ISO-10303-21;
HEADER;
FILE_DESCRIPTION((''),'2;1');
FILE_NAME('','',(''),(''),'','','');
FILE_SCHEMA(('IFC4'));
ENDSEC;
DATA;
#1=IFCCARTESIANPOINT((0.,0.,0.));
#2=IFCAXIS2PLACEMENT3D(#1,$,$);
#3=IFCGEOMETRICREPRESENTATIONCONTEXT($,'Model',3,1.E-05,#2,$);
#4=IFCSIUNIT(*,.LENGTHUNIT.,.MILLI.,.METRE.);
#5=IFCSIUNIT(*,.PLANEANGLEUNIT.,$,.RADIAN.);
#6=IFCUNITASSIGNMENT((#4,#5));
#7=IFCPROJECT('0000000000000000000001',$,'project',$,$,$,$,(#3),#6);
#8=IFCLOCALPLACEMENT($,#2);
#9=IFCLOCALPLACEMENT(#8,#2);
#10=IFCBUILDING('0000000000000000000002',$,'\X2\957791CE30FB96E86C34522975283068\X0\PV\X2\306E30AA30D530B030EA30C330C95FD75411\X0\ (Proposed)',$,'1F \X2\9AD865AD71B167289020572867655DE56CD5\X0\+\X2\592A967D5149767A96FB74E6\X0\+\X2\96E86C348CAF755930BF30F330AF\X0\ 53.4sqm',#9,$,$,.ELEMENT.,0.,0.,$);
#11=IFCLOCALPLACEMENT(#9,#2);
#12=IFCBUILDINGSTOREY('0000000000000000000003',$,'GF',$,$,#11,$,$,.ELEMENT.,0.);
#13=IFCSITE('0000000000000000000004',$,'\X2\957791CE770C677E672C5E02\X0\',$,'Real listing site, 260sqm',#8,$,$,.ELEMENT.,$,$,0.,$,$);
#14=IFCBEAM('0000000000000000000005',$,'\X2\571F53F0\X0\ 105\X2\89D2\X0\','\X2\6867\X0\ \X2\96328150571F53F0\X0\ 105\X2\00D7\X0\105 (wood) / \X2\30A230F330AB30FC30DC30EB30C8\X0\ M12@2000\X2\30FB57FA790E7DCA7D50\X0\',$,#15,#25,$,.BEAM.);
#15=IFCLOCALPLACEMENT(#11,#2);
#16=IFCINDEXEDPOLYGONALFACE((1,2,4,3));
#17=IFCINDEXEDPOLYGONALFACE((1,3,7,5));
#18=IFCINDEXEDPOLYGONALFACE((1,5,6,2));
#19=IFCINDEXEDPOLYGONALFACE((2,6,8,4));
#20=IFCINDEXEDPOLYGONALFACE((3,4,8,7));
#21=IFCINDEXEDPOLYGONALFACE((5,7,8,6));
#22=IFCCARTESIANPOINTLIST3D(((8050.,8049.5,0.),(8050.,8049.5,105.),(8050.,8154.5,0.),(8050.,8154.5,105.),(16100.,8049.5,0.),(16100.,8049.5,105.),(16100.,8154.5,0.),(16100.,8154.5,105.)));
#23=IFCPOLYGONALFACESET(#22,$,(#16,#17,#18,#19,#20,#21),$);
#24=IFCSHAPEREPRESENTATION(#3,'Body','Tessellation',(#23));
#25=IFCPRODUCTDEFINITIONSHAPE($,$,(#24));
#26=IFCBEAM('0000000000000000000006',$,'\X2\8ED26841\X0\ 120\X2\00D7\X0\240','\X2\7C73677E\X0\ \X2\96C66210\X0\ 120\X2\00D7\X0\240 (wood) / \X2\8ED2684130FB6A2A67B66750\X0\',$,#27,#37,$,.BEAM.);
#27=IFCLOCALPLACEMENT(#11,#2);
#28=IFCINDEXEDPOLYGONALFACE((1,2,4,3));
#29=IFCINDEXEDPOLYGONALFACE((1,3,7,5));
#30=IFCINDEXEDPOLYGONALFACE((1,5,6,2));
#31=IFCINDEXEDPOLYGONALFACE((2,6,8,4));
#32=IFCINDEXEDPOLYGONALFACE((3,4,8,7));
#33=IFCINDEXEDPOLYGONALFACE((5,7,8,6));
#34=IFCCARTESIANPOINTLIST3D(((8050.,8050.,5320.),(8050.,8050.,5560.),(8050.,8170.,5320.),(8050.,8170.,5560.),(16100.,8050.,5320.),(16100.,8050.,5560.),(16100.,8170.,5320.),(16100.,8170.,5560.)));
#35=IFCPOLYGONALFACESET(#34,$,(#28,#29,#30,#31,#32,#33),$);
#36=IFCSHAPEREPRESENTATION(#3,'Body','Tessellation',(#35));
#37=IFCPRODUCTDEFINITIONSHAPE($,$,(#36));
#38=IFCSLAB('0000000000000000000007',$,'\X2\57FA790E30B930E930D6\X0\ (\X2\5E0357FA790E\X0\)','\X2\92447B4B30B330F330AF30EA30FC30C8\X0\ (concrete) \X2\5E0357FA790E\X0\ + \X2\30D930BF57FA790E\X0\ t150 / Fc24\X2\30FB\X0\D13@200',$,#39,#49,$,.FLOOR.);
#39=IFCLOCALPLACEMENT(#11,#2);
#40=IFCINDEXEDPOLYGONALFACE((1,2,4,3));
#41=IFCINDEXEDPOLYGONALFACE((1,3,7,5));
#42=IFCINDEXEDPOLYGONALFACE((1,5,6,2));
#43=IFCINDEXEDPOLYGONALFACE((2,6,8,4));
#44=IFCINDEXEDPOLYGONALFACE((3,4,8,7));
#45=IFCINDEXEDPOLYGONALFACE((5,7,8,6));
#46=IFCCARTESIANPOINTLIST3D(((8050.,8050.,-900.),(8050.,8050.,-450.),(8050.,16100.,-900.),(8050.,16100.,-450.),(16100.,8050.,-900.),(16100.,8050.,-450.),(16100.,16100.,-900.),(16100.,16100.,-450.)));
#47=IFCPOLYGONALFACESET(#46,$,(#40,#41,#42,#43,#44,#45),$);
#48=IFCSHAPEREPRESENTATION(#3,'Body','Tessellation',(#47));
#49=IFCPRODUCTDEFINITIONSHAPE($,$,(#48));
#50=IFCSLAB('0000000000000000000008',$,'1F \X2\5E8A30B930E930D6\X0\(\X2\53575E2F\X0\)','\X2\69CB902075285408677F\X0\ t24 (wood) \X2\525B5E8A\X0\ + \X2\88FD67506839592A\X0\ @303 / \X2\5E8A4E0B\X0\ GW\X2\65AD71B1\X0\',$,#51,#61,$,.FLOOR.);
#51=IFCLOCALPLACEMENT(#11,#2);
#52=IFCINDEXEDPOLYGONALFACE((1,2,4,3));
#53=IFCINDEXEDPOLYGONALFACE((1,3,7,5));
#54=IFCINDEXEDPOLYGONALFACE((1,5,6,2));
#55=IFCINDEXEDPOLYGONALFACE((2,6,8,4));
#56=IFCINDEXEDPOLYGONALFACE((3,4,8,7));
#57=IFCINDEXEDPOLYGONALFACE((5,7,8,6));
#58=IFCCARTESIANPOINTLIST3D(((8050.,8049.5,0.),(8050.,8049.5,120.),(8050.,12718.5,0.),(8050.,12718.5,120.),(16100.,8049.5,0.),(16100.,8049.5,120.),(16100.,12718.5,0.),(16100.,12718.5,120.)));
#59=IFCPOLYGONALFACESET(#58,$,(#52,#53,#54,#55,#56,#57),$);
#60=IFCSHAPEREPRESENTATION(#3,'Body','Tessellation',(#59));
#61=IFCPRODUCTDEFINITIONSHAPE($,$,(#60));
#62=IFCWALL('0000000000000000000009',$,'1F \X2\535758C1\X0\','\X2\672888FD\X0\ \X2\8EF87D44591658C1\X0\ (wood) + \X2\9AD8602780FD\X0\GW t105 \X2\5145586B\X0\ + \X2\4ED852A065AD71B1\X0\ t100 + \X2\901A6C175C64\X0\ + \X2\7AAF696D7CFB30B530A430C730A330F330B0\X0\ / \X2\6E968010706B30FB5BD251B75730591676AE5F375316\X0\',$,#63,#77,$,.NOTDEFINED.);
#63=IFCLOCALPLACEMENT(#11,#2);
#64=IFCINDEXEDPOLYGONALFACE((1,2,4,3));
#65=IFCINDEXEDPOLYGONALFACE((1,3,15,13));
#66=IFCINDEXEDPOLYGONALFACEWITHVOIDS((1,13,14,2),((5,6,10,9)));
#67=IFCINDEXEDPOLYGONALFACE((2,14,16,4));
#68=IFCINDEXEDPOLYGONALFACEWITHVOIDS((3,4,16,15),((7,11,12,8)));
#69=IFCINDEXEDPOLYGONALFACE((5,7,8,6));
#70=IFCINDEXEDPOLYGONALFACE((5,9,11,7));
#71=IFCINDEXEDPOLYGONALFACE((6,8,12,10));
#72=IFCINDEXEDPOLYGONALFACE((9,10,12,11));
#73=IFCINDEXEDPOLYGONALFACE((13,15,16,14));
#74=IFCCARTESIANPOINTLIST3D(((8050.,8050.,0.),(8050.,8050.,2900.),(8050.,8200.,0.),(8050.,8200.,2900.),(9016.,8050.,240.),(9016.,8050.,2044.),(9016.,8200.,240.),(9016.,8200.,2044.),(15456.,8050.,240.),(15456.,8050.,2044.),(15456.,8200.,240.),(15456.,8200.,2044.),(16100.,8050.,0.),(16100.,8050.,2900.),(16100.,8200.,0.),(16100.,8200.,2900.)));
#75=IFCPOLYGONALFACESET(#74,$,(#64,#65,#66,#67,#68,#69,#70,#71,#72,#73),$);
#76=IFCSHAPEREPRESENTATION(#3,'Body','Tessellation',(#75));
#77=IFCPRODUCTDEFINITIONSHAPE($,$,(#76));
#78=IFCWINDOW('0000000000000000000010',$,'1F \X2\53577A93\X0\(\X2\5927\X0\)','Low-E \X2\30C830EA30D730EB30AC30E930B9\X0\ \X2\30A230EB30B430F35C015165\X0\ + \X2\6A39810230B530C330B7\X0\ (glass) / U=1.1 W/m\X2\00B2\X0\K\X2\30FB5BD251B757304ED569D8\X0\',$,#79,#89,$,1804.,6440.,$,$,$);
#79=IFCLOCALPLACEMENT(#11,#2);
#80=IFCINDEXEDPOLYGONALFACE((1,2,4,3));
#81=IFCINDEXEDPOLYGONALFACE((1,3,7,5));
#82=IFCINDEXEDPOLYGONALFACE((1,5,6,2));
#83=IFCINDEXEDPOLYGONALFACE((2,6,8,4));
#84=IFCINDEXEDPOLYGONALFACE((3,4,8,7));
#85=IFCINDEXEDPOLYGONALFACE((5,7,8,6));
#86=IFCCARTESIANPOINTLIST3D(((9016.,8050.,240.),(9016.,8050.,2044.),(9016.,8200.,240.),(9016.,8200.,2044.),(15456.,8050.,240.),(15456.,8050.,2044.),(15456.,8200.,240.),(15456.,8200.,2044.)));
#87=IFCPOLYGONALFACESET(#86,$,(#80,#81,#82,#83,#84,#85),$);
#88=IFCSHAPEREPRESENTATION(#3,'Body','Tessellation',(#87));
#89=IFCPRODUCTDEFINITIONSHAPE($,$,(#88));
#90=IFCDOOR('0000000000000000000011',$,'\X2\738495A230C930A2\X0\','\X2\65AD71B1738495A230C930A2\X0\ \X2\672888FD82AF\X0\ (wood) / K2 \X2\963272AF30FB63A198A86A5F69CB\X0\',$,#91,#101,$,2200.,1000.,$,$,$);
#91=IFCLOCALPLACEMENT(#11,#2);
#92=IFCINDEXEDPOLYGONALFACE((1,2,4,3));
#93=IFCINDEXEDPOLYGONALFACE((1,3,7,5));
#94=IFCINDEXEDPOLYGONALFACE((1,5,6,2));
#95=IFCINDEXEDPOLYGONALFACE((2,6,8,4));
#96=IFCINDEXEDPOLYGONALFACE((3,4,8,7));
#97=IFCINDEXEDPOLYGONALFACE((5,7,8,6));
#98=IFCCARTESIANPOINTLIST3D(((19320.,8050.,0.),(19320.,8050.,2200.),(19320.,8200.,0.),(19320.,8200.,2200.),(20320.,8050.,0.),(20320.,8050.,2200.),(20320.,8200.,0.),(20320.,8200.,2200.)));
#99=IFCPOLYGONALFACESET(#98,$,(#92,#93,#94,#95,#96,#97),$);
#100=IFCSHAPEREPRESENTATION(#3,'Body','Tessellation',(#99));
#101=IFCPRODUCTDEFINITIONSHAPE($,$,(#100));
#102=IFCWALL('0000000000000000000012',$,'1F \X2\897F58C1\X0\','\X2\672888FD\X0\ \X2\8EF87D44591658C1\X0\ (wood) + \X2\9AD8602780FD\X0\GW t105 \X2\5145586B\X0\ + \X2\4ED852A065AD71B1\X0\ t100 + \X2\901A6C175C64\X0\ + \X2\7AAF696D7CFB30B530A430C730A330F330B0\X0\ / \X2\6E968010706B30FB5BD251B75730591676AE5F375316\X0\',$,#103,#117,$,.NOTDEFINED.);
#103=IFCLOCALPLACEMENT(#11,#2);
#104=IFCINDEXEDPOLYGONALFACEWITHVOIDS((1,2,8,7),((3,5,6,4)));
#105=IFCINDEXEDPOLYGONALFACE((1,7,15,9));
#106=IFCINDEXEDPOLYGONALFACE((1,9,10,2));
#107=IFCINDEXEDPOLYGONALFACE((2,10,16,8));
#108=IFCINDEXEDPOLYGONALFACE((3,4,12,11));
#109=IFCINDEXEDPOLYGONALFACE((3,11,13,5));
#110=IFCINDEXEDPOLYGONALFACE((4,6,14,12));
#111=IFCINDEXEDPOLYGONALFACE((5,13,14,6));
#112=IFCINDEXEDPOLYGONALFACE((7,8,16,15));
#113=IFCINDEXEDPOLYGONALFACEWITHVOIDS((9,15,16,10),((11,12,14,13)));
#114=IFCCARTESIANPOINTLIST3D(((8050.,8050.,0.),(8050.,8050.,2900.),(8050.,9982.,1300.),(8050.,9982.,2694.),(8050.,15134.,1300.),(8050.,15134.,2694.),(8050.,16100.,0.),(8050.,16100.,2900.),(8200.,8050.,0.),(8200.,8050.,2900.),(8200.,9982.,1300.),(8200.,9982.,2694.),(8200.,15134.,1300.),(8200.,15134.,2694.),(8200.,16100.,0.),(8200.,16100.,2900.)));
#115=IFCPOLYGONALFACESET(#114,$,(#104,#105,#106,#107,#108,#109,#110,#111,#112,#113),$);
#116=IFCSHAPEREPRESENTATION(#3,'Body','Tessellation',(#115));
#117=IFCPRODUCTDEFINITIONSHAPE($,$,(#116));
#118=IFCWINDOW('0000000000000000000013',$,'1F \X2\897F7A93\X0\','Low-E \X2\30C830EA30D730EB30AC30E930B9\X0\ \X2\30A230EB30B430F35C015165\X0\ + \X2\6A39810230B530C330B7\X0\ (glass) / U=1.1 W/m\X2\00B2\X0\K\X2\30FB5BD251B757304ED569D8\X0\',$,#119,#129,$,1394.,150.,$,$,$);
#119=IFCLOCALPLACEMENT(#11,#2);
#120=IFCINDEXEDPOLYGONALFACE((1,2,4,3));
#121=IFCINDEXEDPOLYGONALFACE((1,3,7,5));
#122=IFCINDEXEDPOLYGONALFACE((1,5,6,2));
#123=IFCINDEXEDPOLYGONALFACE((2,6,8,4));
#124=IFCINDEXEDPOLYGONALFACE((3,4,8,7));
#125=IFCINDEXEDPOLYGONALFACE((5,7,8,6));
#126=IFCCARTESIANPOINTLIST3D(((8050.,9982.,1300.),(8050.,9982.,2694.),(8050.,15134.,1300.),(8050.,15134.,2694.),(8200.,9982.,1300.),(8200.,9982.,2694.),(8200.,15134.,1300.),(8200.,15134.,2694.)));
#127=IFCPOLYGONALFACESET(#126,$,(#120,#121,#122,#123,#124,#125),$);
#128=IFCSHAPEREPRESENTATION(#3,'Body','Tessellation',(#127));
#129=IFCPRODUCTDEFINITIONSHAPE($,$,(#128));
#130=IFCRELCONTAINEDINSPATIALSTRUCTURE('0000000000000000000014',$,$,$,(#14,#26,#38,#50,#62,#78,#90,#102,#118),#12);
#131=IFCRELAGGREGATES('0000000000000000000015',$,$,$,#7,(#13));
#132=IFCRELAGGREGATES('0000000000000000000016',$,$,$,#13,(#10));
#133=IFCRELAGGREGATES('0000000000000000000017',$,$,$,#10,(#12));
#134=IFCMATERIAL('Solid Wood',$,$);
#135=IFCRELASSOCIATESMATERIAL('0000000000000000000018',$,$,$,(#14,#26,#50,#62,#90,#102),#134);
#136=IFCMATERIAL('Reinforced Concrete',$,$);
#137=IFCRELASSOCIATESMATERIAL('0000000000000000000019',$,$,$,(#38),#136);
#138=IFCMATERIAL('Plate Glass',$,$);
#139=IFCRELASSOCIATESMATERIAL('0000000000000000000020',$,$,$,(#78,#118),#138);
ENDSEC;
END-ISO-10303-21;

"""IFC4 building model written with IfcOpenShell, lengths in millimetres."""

from ifc_helpers import new_model, si_unit, frame, frame_2d, origin, place, context, project, spatial, rectangle, extrude, material, element, fill, save


model = new_model("IFC4")

# Units and contexts
model_context = context("Model", 3, precision=1e-05, world=origin())
ifc_project = project(units=[si_unit("LENGTHUNIT", "METRE", prefix="MILLI"), si_unit("PLANEANGLEUNIT", "RADIAN")], contexts=[model_context])

# Site, building, storey
site_placement = place(None, origin())
site = spatial("IfcSite", under=ifc_project, at=site_placement, Name="長野県松本市", ObjectType="Real listing site, 260sqm", CompositionType="ELEMENT", RefElevation=0.0)
building_placement = place(site_placement, origin())
building = spatial("IfcBuilding", under=site, at=building_placement, Name="長野・雨水利用とPVのオフグリッド志向 (Proposed)", ObjectType="1F 高断熱木造在来工法+太陽光発電瓦+雨水貯留タンク 53.4sqm", CompositionType="ELEMENT", ElevationOfRefHeight=0.0, ElevationOfTerrain=0.0)
storey_placement = place(building_placement, origin())
storey = spatial("IfcBuildingStorey", under=building, at=storey_placement, Name="GF", CompositionType="ELEMENT", Elevation=0.0)

# Shared definitions
ifc_material_1 = material(Name="Solid Wood")

# Beams
beam_1_placement = place(storey_placement, frame((4025.0, 4025.0, 0.0)))
element("IfcBeam", 1, at=beam_1_placement, inside=storey, material=ifc_material_1, Name="土台 105角", Description="桧 防腐土台 105×105 (wood) / アンカーボルト M12@2000・基礎緊結", PredefinedType="BEAM", context=model_context, shape_type="SweptSolid", body=[
    extrude(rectangle(XDim=8050.0, YDim=105.0, at=frame_2d((4025.0, 52.0))), frame((4025.0, 4025.0, 0.0)), (0.0, 0.0, 1.0), 105.0),
])
beam_2_placement = place(storey_placement, frame((4025.0, 4025.0, 2660.0)))
element("IfcBeam", 2, at=beam_2_placement, inside=storey, material=ifc_material_1, Name="軒桁 120×240", Description="米松 集成 120×240 (wood) / 軒桁・横架材", PredefinedType="BEAM", context=model_context, shape_type="SweptSolid", body=[
    extrude(rectangle(XDim=8050.0, YDim=120.0, at=frame_2d((4025.0, 60.0))), frame((4025.0, 4025.0, 2660.0)), (0.0, 0.0, 1.0), 240.0),
])

# Slabs
ifc_material_2 = material(Name="Reinforced Concrete")
slab_1_placement = place(storey_placement, frame((4025.0, 4025.0, -450.0)))
element("IfcSlab", 3, at=slab_1_placement, inside=storey, material=ifc_material_2, Name="基礎スラブ (布基礎)", Description="鉄筋コンクリート (concrete) 布基礎 + ベタ基礎 t150 / Fc24・D13@200", PredefinedType="FLOOR", context=model_context, shape_type="SweptSolid", body=[
    extrude(rectangle(XDim=8050.0, YDim=8050.0, at=frame_2d((4025.0, 4025.0))), frame((4025.0, 4025.0, -450.0)), (0.0, 0.0, 1.0), 450.0),
])
slab_2_placement = place(storey_placement, frame((4025.0, 4025.0, 0.0)))
element("IfcSlab", 4, at=slab_2_placement, inside=storey, material=ifc_material_1, Name="1F 床スラブ(南帯)", Description="構造用合板 t24 (wood) 剛床 + 製材根太 @303 / 床下 GW断熱", PredefinedType="FLOOR", context=model_context, shape_type="SweptSolid", body=[
    extrude(rectangle(XDim=8050.0, YDim=4669.0, at=frame_2d((4025.0, 2334.0))), frame((4025.0, 4025.0, 0.0)), (0.0, 0.0, 1.0), 120.0),
])

# Wall, openings, window, door
wall_1_placement = place(storey_placement, frame((4025.0, 4025.0, 0.0)))
wall_1 = element("IfcWall", 5, at=wall_1_placement, inside=storey, material=ifc_material_1, Name="1F 南壁", Description="木製 軸組外壁 (wood) + 高性能GW t105 充填 + 付加断熱 t100 + 通気層 + 窯業系サイディング / 準耐火・寒冷地外皮強化", PredefinedType="NOTDEFINED", context=model_context, shape_type="SweptSolid", body=[
    extrude(rectangle(XDim=8050.0, YDim=150.0, at=frame_2d((4025.0, 75.0))), frame((4025.0, 4025.0, 0.0)), (0.0, 0.0, 1.0), 2900.0),
])
opening_1_placement = place(storey_placement, frame((4508.0, 4025.0, 120.0)))
opening_1 = element("IfcOpeningElement", 6, at=opening_1_placement, cuts=wall_1, PredefinedType="NOTDEFINED", context=model_context, shape_type="SweptSolid", body=[
    extrude(rectangle(XDim=6440.0, YDim=150.0, at=frame_2d((3220.0, 75.0))), frame((4508.0, 4025.0, 120.0)), (0.0, 0.0, 1.0), 1804.0),
])
opening_2_placement = place(storey_placement, frame((9660.0, 4025.0, 0.0)))
opening_2 = element("IfcOpeningElement", 7, at=opening_2_placement, cuts=wall_1, PredefinedType="NOTDEFINED", context=model_context, shape_type="SweptSolid", body=[
    extrude(rectangle(XDim=1000.0, YDim=150.0, at=frame_2d((500.0, 75.0))), frame((9660.0, 4025.0, 0.0)), (0.0, 0.0, 1.0), 2200.0),
])
ifc_material_3 = material(Name="Plate Glass")
window_1_placement = place(storey_placement, frame((4508.0, 4025.0, 120.0)))
window_1 = element("IfcWindow", 8, at=window_1_placement, inside=storey, material=ifc_material_3, Name="1F 南窓(大)", Description="Low-E トリプルガラス アルゴン封入 + 樹脂サッシ (glass) / U=1.1 W/m²K・寒冷地仕様", OverallHeight=1804.0, OverallWidth=6440.0, context=model_context, shape_type="SweptSolid", body=[
    extrude(rectangle(XDim=6440.0, YDim=150.0, at=frame_2d((3220.0, 75.0))), frame((4508.0, 4025.0, 120.0)), (0.0, 0.0, 1.0), 1804.0),
])
fill(opening_1, window_1)
door_placement = place(storey_placement, frame((9660.0, 4025.0, 0.0)))
door = element("IfcDoor", 9, at=door_placement, inside=storey, material=ifc_material_1, Name="玄関ドア", Description="断熱玄関ドア 木製芯 (wood) / K2 防犯・採風機構", OverallHeight=2200.0, OverallWidth=1000.0, context=model_context, shape_type="SweptSolid", body=[
    extrude(rectangle(XDim=1000.0, YDim=150.0, at=frame_2d((500.0, 75.0))), frame((9660.0, 4025.0, 0.0)), (0.0, 0.0, 1.0), 2200.0),
])
fill(opening_2, door)

# Wall, opening, window
wall_2_placement = place(storey_placement, frame((4025.0, 4025.0, 0.0)))
wall_2 = element("IfcWall", 10, at=wall_2_placement, inside=storey, material=ifc_material_1, Name="1F 西壁", Description="木製 軸組外壁 (wood) + 高性能GW t105 充填 + 付加断熱 t100 + 通気層 + 窯業系サイディング / 準耐火・寒冷地外皮強化", PredefinedType="NOTDEFINED", context=model_context, shape_type="SweptSolid", body=[
    extrude(rectangle(XDim=150.0, YDim=8050.0, at=frame_2d((75.0, 4025.0))), frame((4025.0, 4025.0, 0.0)), (0.0, 0.0, 1.0), 2900.0),
])
opening_3_placement = place(storey_placement, frame((4025.0, 4991.0, 650.0)))
opening_3 = element("IfcOpeningElement", 11, at=opening_3_placement, cuts=wall_2, PredefinedType="NOTDEFINED", context=model_context, shape_type="SweptSolid", body=[
    extrude(rectangle(XDim=150.0, YDim=5152.0, at=frame_2d((75.0, 2576.0))), frame((4025.0, 4991.0, 650.0)), (0.0, 0.0, 1.0), 1394.0),
])
window_2_placement = place(storey_placement, frame((4025.0, 4991.0, 650.0)))
window_2 = element("IfcWindow", 12, at=window_2_placement, inside=storey, material=ifc_material_3, Name="1F 西窓", Description="Low-E トリプルガラス アルゴン封入 + 樹脂サッシ (glass) / U=1.1 W/m²K・寒冷地仕様", OverallHeight=1394.0, OverallWidth=150.0, context=model_context, shape_type="SweptSolid", body=[
    extrude(rectangle(XDim=150.0, YDim=5152.0, at=frame_2d((75.0, 2576.0))), frame((4025.0, 4991.0, 650.0)), (0.0, 0.0, 1.0), 1394.0),
])
fill(opening_3, window_2)

save(model, "model.ifc")
